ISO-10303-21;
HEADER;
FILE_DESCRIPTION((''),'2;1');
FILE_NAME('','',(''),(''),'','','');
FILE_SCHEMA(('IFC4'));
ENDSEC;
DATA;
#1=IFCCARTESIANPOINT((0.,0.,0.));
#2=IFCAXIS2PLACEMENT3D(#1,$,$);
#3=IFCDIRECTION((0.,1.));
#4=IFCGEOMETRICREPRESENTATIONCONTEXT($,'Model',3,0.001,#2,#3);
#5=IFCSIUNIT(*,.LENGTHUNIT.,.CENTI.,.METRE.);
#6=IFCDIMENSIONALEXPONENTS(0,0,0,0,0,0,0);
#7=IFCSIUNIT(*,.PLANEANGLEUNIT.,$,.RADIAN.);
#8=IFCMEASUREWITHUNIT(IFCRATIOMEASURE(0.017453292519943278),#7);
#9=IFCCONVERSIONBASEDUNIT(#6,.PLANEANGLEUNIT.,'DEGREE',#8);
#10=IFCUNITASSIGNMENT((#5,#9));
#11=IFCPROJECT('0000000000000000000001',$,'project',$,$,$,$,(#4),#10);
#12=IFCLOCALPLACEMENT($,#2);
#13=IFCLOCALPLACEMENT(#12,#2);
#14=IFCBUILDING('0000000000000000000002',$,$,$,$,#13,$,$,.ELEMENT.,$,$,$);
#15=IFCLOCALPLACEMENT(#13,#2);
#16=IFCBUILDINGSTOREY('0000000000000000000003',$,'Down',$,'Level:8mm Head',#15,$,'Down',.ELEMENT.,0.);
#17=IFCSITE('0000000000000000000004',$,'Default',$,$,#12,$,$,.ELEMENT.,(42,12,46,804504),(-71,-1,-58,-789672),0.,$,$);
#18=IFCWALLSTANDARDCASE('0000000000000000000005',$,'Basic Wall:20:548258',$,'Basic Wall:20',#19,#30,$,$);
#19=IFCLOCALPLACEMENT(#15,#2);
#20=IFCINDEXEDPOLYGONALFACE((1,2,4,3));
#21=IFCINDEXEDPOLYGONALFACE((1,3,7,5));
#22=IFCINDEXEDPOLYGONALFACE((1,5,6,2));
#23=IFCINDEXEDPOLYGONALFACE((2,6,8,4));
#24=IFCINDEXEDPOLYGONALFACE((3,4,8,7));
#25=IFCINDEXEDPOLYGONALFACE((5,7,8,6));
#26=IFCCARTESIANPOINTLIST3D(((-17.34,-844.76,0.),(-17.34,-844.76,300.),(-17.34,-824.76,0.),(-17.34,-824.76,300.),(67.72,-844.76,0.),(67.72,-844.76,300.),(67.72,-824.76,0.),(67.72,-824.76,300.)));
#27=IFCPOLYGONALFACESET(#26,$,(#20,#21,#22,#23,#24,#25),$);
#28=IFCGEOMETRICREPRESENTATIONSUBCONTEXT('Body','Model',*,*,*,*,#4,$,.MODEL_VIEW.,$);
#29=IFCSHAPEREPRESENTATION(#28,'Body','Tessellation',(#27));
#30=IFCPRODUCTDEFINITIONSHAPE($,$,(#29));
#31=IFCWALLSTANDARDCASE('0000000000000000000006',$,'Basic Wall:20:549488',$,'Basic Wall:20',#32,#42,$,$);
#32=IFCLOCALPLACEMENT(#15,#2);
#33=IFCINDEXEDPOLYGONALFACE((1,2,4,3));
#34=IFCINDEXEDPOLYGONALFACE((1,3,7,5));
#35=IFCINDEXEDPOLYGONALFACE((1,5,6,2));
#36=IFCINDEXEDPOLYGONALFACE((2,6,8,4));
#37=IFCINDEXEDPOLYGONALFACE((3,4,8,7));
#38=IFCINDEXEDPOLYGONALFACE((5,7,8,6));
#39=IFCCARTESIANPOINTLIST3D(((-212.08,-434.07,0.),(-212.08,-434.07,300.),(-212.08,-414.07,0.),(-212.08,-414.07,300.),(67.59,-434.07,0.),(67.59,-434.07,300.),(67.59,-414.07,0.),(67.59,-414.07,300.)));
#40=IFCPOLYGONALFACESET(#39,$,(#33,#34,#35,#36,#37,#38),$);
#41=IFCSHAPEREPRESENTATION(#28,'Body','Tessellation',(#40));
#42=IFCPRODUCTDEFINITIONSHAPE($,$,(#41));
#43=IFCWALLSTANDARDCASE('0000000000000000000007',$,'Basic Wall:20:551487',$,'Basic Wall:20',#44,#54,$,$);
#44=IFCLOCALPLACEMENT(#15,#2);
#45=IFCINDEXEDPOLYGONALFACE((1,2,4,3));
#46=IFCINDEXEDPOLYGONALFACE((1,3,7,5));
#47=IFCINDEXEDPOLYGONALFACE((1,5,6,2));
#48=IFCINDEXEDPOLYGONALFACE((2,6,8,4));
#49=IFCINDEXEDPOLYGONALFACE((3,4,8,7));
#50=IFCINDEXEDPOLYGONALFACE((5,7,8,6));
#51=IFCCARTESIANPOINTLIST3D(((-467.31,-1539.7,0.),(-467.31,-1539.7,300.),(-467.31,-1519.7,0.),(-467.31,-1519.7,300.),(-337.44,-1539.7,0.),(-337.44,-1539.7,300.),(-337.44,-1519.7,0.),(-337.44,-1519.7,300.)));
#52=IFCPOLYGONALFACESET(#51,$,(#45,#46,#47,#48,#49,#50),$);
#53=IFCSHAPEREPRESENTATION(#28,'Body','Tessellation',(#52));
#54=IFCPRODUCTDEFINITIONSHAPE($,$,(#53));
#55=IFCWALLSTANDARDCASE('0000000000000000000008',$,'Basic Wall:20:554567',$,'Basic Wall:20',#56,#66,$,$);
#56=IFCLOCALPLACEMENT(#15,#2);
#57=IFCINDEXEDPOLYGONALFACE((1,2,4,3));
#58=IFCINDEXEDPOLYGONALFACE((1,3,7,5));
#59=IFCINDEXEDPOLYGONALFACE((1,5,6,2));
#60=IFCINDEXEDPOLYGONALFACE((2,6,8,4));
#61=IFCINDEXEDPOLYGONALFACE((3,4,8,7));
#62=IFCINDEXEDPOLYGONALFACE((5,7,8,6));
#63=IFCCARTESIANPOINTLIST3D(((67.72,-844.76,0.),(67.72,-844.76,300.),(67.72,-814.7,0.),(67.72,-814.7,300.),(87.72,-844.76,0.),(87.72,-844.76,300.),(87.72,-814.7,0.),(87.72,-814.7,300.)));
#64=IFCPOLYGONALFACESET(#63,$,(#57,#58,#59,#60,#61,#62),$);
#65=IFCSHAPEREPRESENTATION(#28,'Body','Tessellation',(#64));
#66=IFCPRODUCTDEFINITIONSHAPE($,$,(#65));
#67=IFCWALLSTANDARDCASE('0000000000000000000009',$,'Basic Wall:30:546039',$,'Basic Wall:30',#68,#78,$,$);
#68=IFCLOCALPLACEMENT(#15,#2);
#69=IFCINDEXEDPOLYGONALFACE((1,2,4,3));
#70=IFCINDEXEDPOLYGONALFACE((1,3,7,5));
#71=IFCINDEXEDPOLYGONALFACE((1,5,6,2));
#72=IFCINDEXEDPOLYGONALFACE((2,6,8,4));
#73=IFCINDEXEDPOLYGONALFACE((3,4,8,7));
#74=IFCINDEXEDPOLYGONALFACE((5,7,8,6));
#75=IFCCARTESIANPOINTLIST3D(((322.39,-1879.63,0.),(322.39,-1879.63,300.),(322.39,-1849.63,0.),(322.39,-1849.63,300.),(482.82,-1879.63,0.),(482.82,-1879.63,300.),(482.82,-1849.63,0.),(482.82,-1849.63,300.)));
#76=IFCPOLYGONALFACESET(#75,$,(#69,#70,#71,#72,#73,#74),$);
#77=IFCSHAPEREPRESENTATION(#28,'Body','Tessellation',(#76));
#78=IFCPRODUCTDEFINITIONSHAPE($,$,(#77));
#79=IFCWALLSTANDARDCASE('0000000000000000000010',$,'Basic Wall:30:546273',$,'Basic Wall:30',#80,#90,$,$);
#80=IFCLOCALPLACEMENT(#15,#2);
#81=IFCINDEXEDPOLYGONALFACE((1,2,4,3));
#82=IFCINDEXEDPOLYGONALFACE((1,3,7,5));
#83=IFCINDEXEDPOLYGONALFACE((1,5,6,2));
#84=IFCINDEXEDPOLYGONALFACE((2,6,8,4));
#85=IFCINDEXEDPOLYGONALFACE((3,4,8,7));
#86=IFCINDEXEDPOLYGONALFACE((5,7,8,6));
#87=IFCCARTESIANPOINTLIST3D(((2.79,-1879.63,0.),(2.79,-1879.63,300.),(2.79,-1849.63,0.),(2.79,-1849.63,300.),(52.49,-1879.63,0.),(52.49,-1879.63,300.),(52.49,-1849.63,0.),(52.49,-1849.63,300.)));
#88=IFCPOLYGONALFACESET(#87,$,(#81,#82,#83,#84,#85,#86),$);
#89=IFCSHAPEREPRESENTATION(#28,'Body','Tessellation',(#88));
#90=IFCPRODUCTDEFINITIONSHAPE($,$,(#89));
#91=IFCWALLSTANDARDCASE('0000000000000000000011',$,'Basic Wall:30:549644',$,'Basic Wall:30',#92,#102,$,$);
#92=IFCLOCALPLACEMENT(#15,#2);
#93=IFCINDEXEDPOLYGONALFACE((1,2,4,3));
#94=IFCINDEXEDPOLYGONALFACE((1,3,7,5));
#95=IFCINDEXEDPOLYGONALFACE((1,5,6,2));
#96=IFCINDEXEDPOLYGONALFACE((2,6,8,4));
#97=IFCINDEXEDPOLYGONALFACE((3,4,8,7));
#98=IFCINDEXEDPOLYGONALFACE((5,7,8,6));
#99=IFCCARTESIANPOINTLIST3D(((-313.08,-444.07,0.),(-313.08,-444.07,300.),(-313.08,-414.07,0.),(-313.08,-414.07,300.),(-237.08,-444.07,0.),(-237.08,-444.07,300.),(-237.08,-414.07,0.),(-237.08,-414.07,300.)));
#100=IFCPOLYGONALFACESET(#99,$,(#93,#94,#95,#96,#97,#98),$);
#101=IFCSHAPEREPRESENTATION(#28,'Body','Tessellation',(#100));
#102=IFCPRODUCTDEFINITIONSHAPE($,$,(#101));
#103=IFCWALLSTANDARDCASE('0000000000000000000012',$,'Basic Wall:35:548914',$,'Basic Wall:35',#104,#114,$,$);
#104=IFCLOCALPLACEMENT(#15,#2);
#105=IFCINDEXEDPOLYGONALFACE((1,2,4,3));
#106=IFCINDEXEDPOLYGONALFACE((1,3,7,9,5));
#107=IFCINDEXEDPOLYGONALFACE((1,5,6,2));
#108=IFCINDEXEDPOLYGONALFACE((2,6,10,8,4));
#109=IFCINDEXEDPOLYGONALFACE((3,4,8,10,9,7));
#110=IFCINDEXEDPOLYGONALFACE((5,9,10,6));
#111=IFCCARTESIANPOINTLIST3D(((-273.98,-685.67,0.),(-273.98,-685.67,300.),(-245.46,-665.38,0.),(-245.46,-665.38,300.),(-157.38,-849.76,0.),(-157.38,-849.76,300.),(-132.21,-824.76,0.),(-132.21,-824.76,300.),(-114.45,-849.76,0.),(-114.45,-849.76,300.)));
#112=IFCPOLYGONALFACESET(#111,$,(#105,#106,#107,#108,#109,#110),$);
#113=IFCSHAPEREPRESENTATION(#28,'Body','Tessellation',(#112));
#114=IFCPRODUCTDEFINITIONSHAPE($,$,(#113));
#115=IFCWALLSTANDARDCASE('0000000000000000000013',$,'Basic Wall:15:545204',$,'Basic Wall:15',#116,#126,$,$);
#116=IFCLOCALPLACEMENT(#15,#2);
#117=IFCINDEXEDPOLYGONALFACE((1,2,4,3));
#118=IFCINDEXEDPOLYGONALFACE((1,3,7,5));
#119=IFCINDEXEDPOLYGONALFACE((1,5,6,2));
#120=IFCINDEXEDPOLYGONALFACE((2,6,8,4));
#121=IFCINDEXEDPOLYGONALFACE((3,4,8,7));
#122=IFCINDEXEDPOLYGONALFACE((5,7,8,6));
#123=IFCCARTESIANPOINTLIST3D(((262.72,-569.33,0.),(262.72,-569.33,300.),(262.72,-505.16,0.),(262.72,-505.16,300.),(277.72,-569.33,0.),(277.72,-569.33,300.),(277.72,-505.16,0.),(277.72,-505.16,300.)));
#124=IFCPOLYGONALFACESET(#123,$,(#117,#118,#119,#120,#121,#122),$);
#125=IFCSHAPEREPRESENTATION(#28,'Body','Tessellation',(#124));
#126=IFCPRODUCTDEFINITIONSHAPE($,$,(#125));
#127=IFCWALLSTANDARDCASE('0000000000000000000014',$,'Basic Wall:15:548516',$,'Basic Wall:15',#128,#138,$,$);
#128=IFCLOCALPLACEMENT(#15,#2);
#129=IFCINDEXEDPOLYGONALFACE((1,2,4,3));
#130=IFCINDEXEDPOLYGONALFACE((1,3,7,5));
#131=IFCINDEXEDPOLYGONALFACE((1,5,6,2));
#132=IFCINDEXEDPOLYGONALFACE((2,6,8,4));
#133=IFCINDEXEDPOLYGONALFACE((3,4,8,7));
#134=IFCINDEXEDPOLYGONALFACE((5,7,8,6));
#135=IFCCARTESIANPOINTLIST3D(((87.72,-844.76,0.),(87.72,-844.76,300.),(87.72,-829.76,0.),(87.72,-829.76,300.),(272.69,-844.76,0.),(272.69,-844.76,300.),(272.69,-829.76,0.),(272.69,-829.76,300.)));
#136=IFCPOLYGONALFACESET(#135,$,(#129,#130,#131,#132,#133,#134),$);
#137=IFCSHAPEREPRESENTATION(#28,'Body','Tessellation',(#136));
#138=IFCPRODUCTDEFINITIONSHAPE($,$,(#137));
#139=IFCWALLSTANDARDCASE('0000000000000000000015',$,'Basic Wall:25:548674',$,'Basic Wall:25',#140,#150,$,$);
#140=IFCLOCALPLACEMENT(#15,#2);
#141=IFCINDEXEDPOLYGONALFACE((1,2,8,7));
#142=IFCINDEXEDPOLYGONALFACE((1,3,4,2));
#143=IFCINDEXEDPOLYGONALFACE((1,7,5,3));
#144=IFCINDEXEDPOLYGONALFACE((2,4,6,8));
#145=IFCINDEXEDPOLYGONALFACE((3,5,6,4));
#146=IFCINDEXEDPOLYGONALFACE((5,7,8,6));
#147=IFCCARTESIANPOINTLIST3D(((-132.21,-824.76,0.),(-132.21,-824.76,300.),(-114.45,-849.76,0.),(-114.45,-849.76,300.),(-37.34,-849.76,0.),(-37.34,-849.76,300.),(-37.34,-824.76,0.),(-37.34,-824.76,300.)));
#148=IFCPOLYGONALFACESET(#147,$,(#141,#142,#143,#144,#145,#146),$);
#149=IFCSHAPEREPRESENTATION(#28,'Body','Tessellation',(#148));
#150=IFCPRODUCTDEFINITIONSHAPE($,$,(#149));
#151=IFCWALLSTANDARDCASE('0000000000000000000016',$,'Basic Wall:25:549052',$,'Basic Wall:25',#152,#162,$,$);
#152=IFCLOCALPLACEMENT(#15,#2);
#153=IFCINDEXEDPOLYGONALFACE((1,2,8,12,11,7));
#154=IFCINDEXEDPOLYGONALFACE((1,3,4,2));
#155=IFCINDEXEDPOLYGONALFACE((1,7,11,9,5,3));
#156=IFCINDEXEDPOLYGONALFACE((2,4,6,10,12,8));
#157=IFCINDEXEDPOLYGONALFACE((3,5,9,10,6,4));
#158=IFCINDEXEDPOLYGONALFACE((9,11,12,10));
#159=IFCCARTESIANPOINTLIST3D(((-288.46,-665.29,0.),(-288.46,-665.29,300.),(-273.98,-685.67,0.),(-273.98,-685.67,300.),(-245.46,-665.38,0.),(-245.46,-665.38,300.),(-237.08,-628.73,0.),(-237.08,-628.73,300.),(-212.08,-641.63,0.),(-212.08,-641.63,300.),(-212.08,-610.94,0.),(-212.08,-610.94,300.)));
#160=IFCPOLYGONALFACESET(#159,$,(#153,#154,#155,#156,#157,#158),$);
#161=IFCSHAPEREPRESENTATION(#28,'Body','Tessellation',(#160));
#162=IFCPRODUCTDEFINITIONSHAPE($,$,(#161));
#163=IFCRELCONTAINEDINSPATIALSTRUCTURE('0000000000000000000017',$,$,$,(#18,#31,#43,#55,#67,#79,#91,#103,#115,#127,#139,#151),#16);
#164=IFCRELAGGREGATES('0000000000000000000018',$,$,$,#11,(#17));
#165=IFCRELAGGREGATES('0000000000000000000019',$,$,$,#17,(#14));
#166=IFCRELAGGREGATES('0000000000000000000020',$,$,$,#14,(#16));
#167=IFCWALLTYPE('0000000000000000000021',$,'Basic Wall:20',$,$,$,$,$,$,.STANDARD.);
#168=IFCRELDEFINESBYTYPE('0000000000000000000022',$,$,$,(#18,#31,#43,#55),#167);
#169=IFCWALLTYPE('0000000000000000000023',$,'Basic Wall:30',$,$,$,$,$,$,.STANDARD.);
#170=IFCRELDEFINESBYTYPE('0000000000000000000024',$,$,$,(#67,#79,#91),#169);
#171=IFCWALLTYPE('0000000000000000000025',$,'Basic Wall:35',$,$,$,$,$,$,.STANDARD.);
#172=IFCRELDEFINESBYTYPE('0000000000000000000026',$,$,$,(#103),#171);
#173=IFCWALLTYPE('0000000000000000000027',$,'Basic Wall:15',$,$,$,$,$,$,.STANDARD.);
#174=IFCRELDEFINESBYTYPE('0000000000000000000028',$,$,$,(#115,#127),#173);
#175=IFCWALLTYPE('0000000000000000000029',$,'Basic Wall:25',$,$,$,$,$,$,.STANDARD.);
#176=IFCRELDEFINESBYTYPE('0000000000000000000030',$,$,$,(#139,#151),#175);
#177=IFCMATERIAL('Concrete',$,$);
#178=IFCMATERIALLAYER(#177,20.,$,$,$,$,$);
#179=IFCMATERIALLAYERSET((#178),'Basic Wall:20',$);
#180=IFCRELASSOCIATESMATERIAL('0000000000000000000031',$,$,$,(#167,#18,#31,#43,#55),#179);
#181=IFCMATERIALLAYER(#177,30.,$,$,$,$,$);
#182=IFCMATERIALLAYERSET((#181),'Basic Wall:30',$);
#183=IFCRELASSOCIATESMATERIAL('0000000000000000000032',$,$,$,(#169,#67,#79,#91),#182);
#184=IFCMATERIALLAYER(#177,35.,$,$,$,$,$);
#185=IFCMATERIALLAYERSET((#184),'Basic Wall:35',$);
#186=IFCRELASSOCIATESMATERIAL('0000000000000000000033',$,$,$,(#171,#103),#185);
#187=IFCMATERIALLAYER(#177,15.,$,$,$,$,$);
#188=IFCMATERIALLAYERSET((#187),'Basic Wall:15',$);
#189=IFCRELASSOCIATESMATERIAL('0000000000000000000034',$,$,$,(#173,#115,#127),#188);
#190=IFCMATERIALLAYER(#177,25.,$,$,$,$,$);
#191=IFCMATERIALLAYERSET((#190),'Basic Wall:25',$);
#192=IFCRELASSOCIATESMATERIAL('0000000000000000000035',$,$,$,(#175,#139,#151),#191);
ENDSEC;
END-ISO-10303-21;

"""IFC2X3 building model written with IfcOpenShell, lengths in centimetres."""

from ifc_helpers import new_model, entity, si_unit, converted_unit, direction, frame, frame_2d, origin, place, context, subcontext, project, spatial, polyline, rectangle, outline, extrude, clip, bounded_halfspace, material, layer, layer_set, layer_usage, type_object, element, save


model = new_model("IFC2X3")

# Units and contexts
model_context = context("Model", 3, precision=0.001, world=origin(), true_north=direction((0.0, 1.0)))
body_context = subcontext(model_context, "Body", "Model", "MODEL_VIEW")
ifc_project = project(units=[si_unit("LENGTHUNIT", "METRE", prefix="CENTI"), converted_unit("PLANEANGLEUNIT", "DEGREE", entity("IfcRatioMeasure", 0.017453292519943278), si_unit("PLANEANGLEUNIT", "RADIAN"), dimensions=[0, 0, 0, 0, 0, 0, 0])], contexts=[model_context])

# Site, building, storey
site_placement = place(None, origin())
site = spatial("IfcSite", under=ifc_project, at=site_placement, Name="Default", CompositionType="ELEMENT", RefLatitude=(42, 12, 46, 804504), RefLongitude=(-71, -1, -58, -789672), RefElevation=0.0)
building_placement = place(site_placement, origin())
building = spatial("IfcBuilding", under=site, at=building_placement, CompositionType="ELEMENT")
storey_placement = place(building_placement, origin())
storey = spatial("IfcBuildingStorey", under=building, at=storey_placement, Name="Down", ObjectType="Level:8mm Head", LongName="Down", CompositionType="ELEMENT", Elevation=0.0)

# Walls
ifc_material = material(Name="Concrete")
ifc_layer_1 = layer(ifc_material, 20.0)
ifc_layer_set_1 = layer_set([ifc_layer_1], Name="Basic Wall:20")
wall_type_1 = type_object("IfcWallType", Name="Basic Wall:20", PredefinedType="STANDARD", material=ifc_layer_set_1)
ifc_layer_usage_1 = layer_usage(ifc_layer_set_1, "AXIS2", "POSITIVE", -10.0)
wall_1_placement = place(storey_placement, frame((-17.34, -834.76, 0.0)))
element("IfcWallStandardCase", 1, at=wall_1_placement, inside=storey, type_object=wall_type_1, material=ifc_layer_usage_1, Name="Basic Wall:20:548258", ObjectType="Basic Wall:20", context=body_context, shape_type="SweptSolid", body=[
    extrude(rectangle(XDim=85.07, YDim=20.0, at=frame_2d((42.53, 0.0), x_axis=(-1.0, 0.0))), origin(), (0.0, 0.0, 1.0), 300.0),
])
ifc_layer_usage_2 = layer_usage(ifc_layer_set_1, "AXIS2", "POSITIVE", -10.0)
wall_2_placement = place(storey_placement, frame((-212.08, -424.07, 0.0)))
element("IfcWallStandardCase", 2, at=wall_2_placement, inside=storey, type_object=wall_type_1, material=ifc_layer_usage_2, Name="Basic Wall:20:549488", ObjectType="Basic Wall:20", context=body_context, shape_type="SweptSolid", body=[
    extrude(rectangle(XDim=279.67, YDim=20.0, at=frame_2d((139.84, 0.0), x_axis=(-1.0, 0.0))), origin(), (0.0, 0.0, 1.0), 300.0),
])
ifc_layer_usage_3 = layer_usage(ifc_layer_set_1, "AXIS2", "POSITIVE", -10.0)
wall_3_placement = place(storey_placement, frame((-467.31, -1529.7, 0.0)))
element("IfcWallStandardCase", 3, at=wall_3_placement, inside=storey, type_object=wall_type_1, material=ifc_layer_usage_3, Name="Basic Wall:20:551487", ObjectType="Basic Wall:20", context=body_context, shape_type="Clipping", body=[
    clip(extrude(rectangle(XDim=129.87, YDim=20.0, at=frame_2d((64.93, 0.0), x_axis=(-1.0, 0.0))), origin(), (0.0, 0.0, 1.0), 300.0), bounded_halfspace(frame((0.0, -10.0, 0.0), z_axis=(1.0, 0.0, 0.0), x_axis=(0.0, 0.0, -1.0)), True, frame((0.0, -10.0, 0.0), z_axis=(1.0, 0.0, 0.0), x_axis=(0.0, 0.0, -1.0)), polyline([(0.0, 0.0), (0.0, 20.0), (-280.0, 20.0), (-300.0, 20.0), (-300.0, 0.0), (0.0, 0.0)]))),
])
ifc_layer_usage_4 = layer_usage(ifc_layer_set_1, "AXIS2", "NEGATIVE", 10.0)
wall_4_placement = place(storey_placement, frame((77.72, -814.7, 0.0), z_axis=(0.0, 0.0, 1.0), x_axis=(0.0, -1.0, 0.0)))
element("IfcWallStandardCase", 4, at=wall_4_placement, inside=storey, type_object=wall_type_1, material=ifc_layer_usage_4, Name="Basic Wall:20:554567", ObjectType="Basic Wall:20", context=body_context, shape_type="SweptSolid", body=[
    extrude(rectangle(XDim=30.07, YDim=20.0, at=frame_2d((15.03, 0.0), x_axis=(-1.0, 0.0))), origin(), (0.0, 0.0, 1.0), 300.0),
])
ifc_layer_2 = layer(ifc_material, 30.0)
ifc_layer_set_2 = layer_set([ifc_layer_2], Name="Basic Wall:30")
ifc_layer_usage_5 = layer_usage(ifc_layer_set_2, "AXIS2", "NEGATIVE", 15.0)
wall_type_2 = type_object("IfcWallType", Name="Basic Wall:30", PredefinedType="STANDARD", material=ifc_layer_set_2)
wall_5_placement = place(storey_placement, frame((322.39, -1864.63, 0.0)))
element("IfcWallStandardCase", 5, at=wall_5_placement, inside=storey, type_object=wall_type_2, material=ifc_layer_usage_5, Name="Basic Wall:30:546039", ObjectType="Basic Wall:30", context=body_context, shape_type="SweptSolid", body=[
    extrude(rectangle(XDim=160.43, YDim=30.0, at=frame_2d((80.22, 0.0), x_axis=(-1.0, 0.0))), origin(), (0.0, 0.0, 1.0), 300.0),
])
ifc_layer_usage_6 = layer_usage(ifc_layer_set_2, "AXIS2", "POSITIVE", -15.0)
wall_6_placement = place(storey_placement, frame((52.49, -1864.63, 0.0), z_axis=(0.0, 0.0, 1.0), x_axis=(-1.0, 0.0, 0.0)))
element("IfcWallStandardCase", 6, at=wall_6_placement, inside=storey, type_object=wall_type_2, material=ifc_layer_usage_6, Name="Basic Wall:30:546273", ObjectType="Basic Wall:30", context=body_context, shape_type="SweptSolid", body=[
    extrude(rectangle(XDim=49.7, YDim=30.0, at=frame_2d((24.85, 0.0), x_axis=(-1.0, 0.0))), origin(), (0.0, 0.0, 1.0), 300.0),
])
ifc_layer_usage_7 = layer_usage(ifc_layer_set_2, "AXIS2", "POSITIVE", -15.0)
wall_7_placement = place(storey_placement, frame((-237.08, -429.07, 0.0), z_axis=(0.0, 0.0, 1.0), x_axis=(-1.0, 0.0, 0.0)))
element("IfcWallStandardCase", 7, at=wall_7_placement, inside=storey, type_object=wall_type_2, material=ifc_layer_usage_7, Name="Basic Wall:30:549644", ObjectType="Basic Wall:30", context=body_context, shape_type="SweptSolid", body=[
    extrude(rectangle(XDim=76.0, YDim=30.0, at=frame_2d((38.0, 0.0), x_axis=(-1.0, 0.0))), origin(), (0.0, 0.0, 1.0), 300.0),
])
ifc_layer_3 = layer(ifc_material, 35.0)
ifc_layer_set_3 = layer_set([ifc_layer_3], Name="Basic Wall:35")
ifc_layer_usage_8 = layer_usage(ifc_layer_set_3, "AXIS2", "NEGATIVE", 17.5)
wall_type_3 = type_object("IfcWallType", Name="Basic Wall:35", PredefinedType="STANDARD", material=ifc_layer_set_3)
wall_8_placement = place(storey_placement, frame((-128.71, -859.9, 0.0), z_axis=(0.0, 0.0, 1.0), x_axis=(-0.579207, 0.81518, 0.0)))
element("IfcWallStandardCase", 8, at=wall_8_placement, inside=storey, type_object=wall_type_3, material=ifc_layer_usage_8, Name="Basic Wall:35:548914", ObjectType="Basic Wall:35", context=body_context, shape_type="SweptSolid", body=[
    extrude(outline(polyline([(226.19, -17.5), (226.17, 17.5), (24.87, 17.5), (0.0, -17.5), (30.67, -17.5), (226.19, -17.5)])), origin(), (0.0, 0.0, 1.0), 300.0),
])
ifc_layer_4 = layer(ifc_material, 15.0)
ifc_layer_set_4 = layer_set([ifc_layer_4], Name="Basic Wall:15")
ifc_layer_usage_9 = layer_usage(ifc_layer_set_4, "AXIS2", "POSITIVE", -7.5)
wall_type_4 = type_object("IfcWallType", Name="Basic Wall:15", PredefinedType="STANDARD", material=ifc_layer_set_4)
wall_9_placement = place(storey_placement, frame((270.22, -569.33, 0.0), z_axis=(0.0, 0.0, 1.0), x_axis=(0.0, 1.0, 0.0)))
element("IfcWallStandardCase", 9, at=wall_9_placement, inside=storey, type_object=wall_type_4, material=ifc_layer_usage_9, Name="Basic Wall:15:545204", ObjectType="Basic Wall:15", context=body_context, shape_type="SweptSolid", body=[
    extrude(rectangle(XDim=64.17, YDim=15.0, at=frame_2d((32.09, 0.0), x_axis=(-1.0, 0.0))), origin(), (0.0, 0.0, 1.0), 300.0),
])
ifc_layer_usage_10 = layer_usage(ifc_layer_set_4, "AXIS2", "POSITIVE", -7.5)
wall_10_placement = place(storey_placement, frame((87.72, -837.26, 0.0)))
element("IfcWallStandardCase", 10, at=wall_10_placement, inside=storey, type_object=wall_type_4, material=ifc_layer_usage_10, Name="Basic Wall:15:548516", ObjectType="Basic Wall:15", context=body_context, shape_type="SweptSolid", body=[
    extrude(rectangle(XDim=184.97, YDim=15.0, at=frame_2d((92.48, 0.0), x_axis=(-1.0, 0.0))), origin(), (0.0, 0.0, 1.0), 300.0),
])
ifc_layer_5 = layer(ifc_material, 25.0)
ifc_layer_set_5 = layer_set([ifc_layer_5], Name="Basic Wall:25")
ifc_layer_usage_11 = layer_usage(ifc_layer_set_5, "AXIS2", "POSITIVE", -12.5)
wall_type_5 = type_object("IfcWallType", Name="Basic Wall:25", PredefinedType="STANDARD", material=ifc_layer_set_5)
wall_11_placement = place(storey_placement, frame((-37.34, -837.26, 0.0), z_axis=(0.0, 0.0, 1.0), x_axis=(-1.0, 0.0, 0.0)))
element("IfcWallStandardCase", 11, at=wall_11_placement, inside=storey, type_object=wall_type_5, material=ifc_layer_usage_11, Name="Basic Wall:25:548674", ObjectType="Basic Wall:25", context=body_context, shape_type="SweptSolid", body=[
    extrude(outline(polyline([(94.87, -12.5), (77.11, 12.5), (0.0, 12.5), (0.0, -12.5), (94.87, -12.5)])), origin(), (0.0, 0.0, 1.0), 300.0),
])
ifc_layer_usage_12 = layer_usage(ifc_layer_set_5, "AXIS2", "NEGATIVE", 12.5)
wall_12_placement = place(storey_placement, frame((-281.22, -675.48, 0.0), z_axis=(0.0, 0.0, 1.0), x_axis=(0.814791, 0.579755, 0.0)))
element("IfcWallStandardCase", 12, at=wall_12_placement, inside=storey, type_object=wall_type_5, material=ifc_layer_usage_12, Name="Basic Wall:25:549052", ObjectType="Basic Wall:25", context=body_context, shape_type="SweptSolid", body=[
    extrude(outline(polyline([(75.97, -12.5), (93.76, 12.5), (63.07, 12.5), (0.02, 12.5), (0.0, -12.5), (35.0, -12.5), (75.97, -12.5)])), origin(), (0.0, 0.0, 1.0), 300.0),
])

save(model, "model.ifc")
